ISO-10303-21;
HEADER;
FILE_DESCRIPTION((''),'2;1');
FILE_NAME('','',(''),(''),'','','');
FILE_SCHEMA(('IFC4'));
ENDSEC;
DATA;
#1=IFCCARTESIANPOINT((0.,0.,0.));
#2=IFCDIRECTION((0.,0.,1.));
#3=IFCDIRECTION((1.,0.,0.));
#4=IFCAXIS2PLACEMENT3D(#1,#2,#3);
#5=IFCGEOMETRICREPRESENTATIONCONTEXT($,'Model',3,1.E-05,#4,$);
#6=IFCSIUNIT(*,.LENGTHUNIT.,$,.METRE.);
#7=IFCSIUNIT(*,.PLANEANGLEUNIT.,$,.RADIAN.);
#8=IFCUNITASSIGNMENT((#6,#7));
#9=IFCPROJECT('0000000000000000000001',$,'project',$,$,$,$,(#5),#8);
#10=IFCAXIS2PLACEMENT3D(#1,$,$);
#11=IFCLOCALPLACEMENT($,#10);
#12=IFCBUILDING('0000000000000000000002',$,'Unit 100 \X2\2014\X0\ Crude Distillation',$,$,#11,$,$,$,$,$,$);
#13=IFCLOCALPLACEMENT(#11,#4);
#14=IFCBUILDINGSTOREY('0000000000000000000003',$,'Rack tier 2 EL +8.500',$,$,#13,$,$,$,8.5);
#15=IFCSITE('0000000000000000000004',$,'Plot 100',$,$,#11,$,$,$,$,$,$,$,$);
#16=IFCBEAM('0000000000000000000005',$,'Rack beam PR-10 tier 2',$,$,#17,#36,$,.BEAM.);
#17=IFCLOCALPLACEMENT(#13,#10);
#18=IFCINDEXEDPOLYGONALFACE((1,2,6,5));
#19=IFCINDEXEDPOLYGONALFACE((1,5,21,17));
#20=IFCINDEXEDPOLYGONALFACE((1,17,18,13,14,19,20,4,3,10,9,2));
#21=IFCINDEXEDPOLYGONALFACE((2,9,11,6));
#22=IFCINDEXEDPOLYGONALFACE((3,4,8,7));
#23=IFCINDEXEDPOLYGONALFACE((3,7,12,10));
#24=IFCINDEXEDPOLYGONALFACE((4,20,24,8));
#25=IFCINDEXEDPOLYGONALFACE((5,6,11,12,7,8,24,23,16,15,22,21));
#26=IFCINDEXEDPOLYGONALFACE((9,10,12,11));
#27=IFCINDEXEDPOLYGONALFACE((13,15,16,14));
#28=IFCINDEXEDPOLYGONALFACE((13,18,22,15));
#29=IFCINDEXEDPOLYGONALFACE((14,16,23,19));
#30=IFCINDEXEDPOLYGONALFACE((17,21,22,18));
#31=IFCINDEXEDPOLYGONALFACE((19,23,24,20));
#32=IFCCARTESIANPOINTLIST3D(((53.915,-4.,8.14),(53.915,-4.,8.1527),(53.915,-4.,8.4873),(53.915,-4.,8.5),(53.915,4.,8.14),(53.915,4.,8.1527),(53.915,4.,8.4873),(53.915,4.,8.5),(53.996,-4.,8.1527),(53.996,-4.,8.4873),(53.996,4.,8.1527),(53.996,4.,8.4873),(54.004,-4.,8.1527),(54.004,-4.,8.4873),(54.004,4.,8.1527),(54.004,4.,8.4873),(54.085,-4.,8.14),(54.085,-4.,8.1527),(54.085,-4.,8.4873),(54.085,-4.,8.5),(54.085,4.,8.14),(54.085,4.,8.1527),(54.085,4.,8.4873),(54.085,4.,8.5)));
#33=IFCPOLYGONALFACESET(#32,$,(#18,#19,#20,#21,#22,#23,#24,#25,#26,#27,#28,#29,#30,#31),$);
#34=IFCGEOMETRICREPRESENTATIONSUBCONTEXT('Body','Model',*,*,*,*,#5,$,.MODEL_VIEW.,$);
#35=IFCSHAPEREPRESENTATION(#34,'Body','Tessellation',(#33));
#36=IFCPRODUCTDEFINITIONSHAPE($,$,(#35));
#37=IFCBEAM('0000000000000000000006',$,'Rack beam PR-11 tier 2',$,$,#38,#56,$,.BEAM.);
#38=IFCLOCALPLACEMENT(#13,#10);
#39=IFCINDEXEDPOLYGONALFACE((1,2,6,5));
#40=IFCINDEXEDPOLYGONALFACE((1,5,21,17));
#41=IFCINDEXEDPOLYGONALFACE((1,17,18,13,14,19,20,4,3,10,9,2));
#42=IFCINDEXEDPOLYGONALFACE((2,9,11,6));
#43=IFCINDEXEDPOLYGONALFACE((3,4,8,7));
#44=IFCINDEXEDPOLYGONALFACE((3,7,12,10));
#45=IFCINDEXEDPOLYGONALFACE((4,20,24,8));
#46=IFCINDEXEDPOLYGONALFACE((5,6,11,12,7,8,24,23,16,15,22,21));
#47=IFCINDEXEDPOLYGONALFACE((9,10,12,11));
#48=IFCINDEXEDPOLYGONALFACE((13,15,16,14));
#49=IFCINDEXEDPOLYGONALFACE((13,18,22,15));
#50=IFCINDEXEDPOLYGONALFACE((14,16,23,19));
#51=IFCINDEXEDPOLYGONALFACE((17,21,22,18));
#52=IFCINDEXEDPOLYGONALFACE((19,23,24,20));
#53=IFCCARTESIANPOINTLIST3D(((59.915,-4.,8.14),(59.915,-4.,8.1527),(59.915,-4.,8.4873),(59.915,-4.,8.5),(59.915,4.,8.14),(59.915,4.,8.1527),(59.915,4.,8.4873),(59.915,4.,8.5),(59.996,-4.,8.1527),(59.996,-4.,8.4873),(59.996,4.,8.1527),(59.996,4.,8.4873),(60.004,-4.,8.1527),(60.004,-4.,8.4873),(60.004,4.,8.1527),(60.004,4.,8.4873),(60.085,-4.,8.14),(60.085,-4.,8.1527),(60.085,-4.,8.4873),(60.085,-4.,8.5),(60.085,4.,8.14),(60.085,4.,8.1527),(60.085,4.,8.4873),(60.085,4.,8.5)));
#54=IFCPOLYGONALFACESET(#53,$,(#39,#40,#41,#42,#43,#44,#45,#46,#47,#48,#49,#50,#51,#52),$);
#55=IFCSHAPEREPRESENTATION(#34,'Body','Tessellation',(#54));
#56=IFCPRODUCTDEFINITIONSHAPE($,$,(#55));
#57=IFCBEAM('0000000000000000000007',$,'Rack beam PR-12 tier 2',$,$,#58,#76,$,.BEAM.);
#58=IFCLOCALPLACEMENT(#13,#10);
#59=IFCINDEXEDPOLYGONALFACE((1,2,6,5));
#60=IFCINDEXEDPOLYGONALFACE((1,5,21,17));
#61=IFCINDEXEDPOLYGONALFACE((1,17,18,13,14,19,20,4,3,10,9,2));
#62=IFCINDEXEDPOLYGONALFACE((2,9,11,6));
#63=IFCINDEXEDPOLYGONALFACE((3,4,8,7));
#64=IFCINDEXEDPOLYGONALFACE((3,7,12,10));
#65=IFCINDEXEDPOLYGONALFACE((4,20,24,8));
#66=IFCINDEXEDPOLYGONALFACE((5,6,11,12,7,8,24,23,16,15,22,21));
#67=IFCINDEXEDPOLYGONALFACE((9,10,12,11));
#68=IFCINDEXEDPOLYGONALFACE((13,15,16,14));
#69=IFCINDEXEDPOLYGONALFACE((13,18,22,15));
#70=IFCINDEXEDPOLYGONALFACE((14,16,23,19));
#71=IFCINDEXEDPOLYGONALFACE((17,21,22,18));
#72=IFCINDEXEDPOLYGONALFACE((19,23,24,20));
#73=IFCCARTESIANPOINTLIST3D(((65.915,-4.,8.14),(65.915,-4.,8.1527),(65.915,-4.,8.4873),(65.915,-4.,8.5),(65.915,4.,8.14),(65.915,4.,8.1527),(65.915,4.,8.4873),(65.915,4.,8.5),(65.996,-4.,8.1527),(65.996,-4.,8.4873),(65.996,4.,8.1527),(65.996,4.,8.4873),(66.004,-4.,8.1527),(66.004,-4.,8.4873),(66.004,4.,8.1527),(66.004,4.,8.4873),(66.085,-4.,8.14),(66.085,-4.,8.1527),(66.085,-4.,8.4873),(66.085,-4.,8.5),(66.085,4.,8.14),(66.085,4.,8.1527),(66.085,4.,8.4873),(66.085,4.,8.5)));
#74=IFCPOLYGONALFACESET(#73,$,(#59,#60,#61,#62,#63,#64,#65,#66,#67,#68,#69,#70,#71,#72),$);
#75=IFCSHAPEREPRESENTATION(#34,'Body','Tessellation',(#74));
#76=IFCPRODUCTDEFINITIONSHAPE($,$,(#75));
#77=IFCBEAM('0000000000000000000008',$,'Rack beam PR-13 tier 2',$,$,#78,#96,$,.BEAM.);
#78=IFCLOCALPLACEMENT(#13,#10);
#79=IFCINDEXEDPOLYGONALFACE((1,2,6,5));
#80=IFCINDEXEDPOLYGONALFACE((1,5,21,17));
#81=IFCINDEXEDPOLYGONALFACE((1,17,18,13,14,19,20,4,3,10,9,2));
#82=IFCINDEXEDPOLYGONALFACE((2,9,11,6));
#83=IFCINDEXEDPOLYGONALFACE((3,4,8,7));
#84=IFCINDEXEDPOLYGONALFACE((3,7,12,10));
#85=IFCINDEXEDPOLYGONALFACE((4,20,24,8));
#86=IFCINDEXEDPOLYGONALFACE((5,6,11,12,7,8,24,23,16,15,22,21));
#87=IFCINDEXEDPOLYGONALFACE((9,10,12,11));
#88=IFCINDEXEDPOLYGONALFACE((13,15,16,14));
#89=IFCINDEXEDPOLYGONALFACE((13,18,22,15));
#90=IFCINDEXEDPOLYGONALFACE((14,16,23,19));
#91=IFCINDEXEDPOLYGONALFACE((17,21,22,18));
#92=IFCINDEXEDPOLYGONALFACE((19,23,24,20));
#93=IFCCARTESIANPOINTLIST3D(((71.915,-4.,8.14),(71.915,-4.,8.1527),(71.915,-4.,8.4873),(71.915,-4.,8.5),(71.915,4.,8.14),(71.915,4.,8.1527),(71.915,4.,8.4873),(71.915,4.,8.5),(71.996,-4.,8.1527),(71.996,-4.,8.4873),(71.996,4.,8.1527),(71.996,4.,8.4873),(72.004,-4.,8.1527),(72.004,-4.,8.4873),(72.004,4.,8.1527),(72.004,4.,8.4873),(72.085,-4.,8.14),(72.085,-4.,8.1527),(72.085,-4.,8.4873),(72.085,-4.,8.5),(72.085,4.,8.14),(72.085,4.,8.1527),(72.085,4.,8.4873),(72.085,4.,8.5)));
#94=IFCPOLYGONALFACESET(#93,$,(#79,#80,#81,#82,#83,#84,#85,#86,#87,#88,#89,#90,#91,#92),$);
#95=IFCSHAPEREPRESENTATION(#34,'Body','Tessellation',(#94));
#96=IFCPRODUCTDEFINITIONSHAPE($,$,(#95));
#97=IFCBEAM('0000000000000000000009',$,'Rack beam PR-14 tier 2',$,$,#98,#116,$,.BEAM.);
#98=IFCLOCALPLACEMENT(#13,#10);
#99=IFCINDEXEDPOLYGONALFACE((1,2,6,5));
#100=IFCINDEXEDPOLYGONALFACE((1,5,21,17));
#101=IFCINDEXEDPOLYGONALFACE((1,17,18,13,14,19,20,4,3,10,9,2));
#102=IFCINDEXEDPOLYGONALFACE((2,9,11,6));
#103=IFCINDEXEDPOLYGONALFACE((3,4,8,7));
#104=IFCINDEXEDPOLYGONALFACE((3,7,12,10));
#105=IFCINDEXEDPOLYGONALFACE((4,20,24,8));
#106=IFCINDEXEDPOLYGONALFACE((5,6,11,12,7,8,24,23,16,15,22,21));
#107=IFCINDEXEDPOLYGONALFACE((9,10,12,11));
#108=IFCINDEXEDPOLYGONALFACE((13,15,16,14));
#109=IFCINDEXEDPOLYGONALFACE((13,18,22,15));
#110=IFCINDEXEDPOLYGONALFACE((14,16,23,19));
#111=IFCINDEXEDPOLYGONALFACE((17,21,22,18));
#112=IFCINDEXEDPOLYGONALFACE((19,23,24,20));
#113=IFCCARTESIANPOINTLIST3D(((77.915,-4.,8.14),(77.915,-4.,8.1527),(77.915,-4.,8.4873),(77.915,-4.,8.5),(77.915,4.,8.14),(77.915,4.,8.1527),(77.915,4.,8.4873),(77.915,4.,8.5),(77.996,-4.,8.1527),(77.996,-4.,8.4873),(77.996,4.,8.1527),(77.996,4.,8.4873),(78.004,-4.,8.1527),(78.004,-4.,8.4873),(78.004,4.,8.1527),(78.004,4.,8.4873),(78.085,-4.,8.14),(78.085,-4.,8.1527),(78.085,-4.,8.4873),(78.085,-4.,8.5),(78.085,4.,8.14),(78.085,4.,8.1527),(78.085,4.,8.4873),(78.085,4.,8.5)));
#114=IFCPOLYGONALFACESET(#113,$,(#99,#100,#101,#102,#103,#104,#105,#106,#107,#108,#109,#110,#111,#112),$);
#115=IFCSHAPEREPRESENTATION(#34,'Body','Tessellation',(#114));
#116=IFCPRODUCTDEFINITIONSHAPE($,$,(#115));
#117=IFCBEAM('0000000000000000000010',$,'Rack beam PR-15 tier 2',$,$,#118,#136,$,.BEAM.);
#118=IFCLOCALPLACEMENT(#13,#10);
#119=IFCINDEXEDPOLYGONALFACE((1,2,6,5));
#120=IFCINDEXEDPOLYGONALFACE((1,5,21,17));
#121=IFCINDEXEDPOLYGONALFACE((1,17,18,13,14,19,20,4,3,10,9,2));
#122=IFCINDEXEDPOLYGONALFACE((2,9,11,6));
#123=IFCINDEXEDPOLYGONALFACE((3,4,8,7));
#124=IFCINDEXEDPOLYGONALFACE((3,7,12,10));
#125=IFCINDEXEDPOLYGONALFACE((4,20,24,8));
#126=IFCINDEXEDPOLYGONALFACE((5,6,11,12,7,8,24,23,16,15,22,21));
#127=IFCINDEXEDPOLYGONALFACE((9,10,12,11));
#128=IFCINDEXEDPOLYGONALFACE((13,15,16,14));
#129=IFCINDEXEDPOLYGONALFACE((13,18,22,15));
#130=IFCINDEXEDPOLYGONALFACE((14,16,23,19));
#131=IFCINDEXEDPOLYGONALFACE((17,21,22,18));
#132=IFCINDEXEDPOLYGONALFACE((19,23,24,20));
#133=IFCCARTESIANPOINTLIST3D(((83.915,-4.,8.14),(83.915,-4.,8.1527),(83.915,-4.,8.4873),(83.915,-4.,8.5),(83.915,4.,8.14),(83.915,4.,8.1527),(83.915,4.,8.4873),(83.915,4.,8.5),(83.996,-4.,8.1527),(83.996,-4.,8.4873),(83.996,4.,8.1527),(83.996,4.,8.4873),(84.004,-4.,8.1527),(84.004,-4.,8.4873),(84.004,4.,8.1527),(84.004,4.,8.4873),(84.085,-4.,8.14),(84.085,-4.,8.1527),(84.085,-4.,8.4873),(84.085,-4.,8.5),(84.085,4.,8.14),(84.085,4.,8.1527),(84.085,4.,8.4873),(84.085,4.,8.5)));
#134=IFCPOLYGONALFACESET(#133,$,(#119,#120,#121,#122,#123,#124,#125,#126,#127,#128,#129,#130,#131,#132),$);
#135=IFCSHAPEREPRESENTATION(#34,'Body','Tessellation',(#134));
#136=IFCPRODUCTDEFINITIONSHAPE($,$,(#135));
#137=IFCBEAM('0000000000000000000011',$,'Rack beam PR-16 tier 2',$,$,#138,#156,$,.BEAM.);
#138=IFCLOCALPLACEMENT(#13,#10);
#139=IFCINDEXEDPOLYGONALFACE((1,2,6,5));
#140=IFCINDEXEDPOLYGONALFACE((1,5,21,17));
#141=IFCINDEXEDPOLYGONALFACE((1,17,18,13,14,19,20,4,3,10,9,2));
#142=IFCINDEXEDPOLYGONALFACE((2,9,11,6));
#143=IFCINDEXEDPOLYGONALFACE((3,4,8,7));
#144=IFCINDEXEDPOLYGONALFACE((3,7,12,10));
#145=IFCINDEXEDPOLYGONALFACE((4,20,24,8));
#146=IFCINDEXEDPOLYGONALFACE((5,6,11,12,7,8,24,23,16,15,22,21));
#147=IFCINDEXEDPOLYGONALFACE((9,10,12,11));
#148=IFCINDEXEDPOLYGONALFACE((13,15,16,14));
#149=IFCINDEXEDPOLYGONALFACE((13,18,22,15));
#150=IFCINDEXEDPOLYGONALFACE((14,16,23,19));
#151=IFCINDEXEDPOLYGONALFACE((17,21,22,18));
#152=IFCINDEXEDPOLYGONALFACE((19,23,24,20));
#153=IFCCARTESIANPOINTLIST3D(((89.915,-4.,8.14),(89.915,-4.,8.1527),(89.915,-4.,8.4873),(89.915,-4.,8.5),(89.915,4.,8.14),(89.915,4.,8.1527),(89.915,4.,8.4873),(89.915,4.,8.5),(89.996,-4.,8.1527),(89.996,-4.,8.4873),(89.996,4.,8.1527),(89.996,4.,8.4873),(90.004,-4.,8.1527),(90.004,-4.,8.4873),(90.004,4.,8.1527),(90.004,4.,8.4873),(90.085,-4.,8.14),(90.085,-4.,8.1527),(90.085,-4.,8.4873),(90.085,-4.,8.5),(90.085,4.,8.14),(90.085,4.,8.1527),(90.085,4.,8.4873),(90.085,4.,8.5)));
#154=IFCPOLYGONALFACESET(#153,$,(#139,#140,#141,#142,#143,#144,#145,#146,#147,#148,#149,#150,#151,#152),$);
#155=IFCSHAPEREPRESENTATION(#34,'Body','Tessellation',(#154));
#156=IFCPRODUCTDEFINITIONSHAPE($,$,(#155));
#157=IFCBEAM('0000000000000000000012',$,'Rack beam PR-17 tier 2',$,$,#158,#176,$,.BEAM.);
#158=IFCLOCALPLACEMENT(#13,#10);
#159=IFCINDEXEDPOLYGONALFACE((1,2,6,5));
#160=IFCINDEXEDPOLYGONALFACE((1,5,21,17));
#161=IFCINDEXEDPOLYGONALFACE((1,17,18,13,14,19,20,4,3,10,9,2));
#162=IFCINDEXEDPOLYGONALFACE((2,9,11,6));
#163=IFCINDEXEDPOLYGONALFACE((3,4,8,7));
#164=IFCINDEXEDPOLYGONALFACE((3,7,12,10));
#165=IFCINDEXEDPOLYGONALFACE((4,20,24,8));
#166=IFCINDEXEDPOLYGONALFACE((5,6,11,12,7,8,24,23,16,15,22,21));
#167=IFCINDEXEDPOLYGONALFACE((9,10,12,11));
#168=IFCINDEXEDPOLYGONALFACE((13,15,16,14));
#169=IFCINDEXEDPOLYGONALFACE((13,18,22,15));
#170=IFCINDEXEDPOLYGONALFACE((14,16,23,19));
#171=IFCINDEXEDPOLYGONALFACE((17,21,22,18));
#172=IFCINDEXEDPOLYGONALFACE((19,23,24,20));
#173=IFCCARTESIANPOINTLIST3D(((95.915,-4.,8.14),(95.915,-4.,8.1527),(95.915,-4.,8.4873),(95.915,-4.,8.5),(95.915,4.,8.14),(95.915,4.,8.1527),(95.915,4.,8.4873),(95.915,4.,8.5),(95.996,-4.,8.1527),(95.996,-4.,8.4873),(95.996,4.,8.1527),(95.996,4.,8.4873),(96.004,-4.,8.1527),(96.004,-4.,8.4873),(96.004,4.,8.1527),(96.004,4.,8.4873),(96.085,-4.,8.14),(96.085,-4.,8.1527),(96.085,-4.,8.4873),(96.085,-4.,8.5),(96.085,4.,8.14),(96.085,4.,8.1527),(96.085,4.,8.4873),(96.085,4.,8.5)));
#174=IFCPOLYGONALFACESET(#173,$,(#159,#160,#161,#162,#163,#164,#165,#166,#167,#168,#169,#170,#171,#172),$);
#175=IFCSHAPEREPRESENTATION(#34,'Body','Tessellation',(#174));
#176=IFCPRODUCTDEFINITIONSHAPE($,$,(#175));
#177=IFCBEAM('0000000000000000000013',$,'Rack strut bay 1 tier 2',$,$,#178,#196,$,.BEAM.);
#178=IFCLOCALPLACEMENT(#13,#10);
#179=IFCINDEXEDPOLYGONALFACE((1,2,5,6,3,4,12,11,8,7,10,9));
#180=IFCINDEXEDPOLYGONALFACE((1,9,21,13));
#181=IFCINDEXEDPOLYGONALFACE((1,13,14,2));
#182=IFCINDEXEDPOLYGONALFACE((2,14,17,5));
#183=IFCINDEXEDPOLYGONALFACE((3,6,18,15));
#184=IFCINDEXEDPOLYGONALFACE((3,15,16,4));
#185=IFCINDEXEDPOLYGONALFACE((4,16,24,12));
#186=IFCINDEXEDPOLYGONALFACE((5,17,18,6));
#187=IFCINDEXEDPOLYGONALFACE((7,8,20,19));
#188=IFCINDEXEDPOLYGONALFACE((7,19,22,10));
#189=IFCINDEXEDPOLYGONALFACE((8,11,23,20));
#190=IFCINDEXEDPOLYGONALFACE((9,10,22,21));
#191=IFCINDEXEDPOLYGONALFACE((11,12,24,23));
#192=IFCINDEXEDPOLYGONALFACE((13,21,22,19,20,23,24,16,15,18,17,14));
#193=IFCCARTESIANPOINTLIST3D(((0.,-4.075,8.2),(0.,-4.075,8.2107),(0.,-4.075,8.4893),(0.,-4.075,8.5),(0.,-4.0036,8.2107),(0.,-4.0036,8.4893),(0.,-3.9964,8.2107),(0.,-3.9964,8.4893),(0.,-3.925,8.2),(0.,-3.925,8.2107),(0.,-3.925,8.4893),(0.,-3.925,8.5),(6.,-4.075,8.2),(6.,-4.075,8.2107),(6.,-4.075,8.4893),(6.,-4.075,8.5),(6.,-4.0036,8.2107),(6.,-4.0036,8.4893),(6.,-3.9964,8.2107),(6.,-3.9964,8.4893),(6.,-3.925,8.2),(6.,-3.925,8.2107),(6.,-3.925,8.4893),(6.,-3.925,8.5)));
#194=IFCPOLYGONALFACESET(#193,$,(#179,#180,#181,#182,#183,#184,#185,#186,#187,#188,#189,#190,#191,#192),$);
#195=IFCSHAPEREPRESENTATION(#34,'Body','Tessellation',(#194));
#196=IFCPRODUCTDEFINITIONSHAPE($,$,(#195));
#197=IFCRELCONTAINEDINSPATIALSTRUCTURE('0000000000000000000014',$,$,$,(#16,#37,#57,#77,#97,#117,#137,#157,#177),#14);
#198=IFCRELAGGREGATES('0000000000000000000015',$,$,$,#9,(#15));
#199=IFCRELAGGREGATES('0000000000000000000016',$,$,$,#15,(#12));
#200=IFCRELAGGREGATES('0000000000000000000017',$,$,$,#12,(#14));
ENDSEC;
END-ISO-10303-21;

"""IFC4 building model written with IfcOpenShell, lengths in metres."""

from ifc_helpers import new_model, si_unit, frame, origin, origin_with_axes, origin_2d, place, context, subcontext, project, spatial, i_section, extrude, element, save


model = new_model("IFC4")

# Units and contexts
model_context = context("Model", 3, precision=1e-05, world=origin_with_axes())
body_context = subcontext(model_context, "Body", "Model", "MODEL_VIEW")
ifc_project = project(units=[si_unit("LENGTHUNIT", "METRE"), si_unit("PLANEANGLEUNIT", "RADIAN")], contexts=[model_context])

# Site, building, storey
placement = place(None, origin())
site = spatial("IfcSite", under=ifc_project, at=placement, Name="Plot 100")
building = spatial("IfcBuilding", under=site, at=placement, Name="Unit 100 — Crude Distillation")
storey_placement = place(placement, origin_with_axes())
storey = spatial("IfcBuildingStorey", under=building, at=storey_placement, Name="Rack tier 2 EL +8.500", Elevation=8.5)

# Beams
beam_1_placement = place(storey_placement, origin_with_axes())
element("IfcBeam", 1, at=beam_1_placement, inside=storey, Name="Rack beam PR-10 tier 2", PredefinedType="BEAM", context=body_context, shape_type="SweptSolid", body=[
    extrude(i_section(OverallWidth=0.17, OverallDepth=0.36, WebThickness=0.008, FlangeThickness=0.0127, at=origin_2d()), frame((54.0, -4.0, 8.32), z_axis=(0.0, 1.0, 0.0), x_axis=(-1.0, 0.0, 0.0)), (0.0, 0.0, 1.0), 8.0),
])
beam_2_placement = place(storey_placement, origin_with_axes())
element("IfcBeam", 2, at=beam_2_placement, inside=storey, Name="Rack beam PR-11 tier 2", PredefinedType="BEAM", context=body_context, shape_type="SweptSolid", body=[
    extrude(i_section(OverallWidth=0.17, OverallDepth=0.36, WebThickness=0.008, FlangeThickness=0.0127, at=origin_2d()), frame((60.0, -4.0, 8.32), z_axis=(0.0, 1.0, 0.0), x_axis=(-1.0, 0.0, 0.0)), (0.0, 0.0, 1.0), 8.0),
])
beam_3_placement = place(storey_placement, origin_with_axes())
element("IfcBeam", 3, at=beam_3_placement, inside=storey, Name="Rack beam PR-12 tier 2", PredefinedType="BEAM", context=body_context, shape_type="SweptSolid", body=[
    extrude(i_section(OverallWidth=0.17, OverallDepth=0.36, WebThickness=0.008, FlangeThickness=0.0127, at=origin_2d()), frame((66.0, -4.0, 8.32), z_axis=(0.0, 1.0, 0.0), x_axis=(-1.0, 0.0, 0.0)), (0.0, 0.0, 1.0), 8.0),
])
beam_4_placement = place(storey_placement, origin_with_axes())
element("IfcBeam", 4, at=beam_4_placement, inside=storey, Name="Rack beam PR-13 tier 2", PredefinedType="BEAM", context=body_context, shape_type="SweptSolid", body=[
    extrude(i_section(OverallWidth=0.17, OverallDepth=0.36, WebThickness=0.008, FlangeThickness=0.0127, at=origin_2d()), frame((72.0, -4.0, 8.32), z_axis=(0.0, 1.0, 0.0), x_axis=(-1.0, 0.0, 0.0)), (0.0, 0.0, 1.0), 8.0),
])
beam_5_placement = place(storey_placement, origin_with_axes())
element("IfcBeam", 5, at=beam_5_placement, inside=storey, Name="Rack beam PR-14 tier 2", PredefinedType="BEAM", context=body_context, shape_type="SweptSolid", body=[
    extrude(i_section(OverallWidth=0.17, OverallDepth=0.36, WebThickness=0.008, FlangeThickness=0.0127, at=origin_2d()), frame((78.0, -4.0, 8.32), z_axis=(0.0, 1.0, 0.0), x_axis=(-1.0, 0.0, 0.0)), (0.0, 0.0, 1.0), 8.0),
])
beam_6_placement = place(storey_placement, origin_with_axes())
element("IfcBeam", 6, at=beam_6_placement, inside=storey, Name="Rack beam PR-15 tier 2", PredefinedType="BEAM", context=body_context, shape_type="SweptSolid", body=[
    extrude(i_section(OverallWidth=0.17, OverallDepth=0.36, WebThickness=0.008, FlangeThickness=0.0127, at=origin_2d()), frame((84.0, -4.0, 8.32), z_axis=(0.0, 1.0, 0.0), x_axis=(-1.0, 0.0, 0.0)), (0.0, 0.0, 1.0), 8.0),
])
beam_7_placement = place(storey_placement, origin_with_axes())
element("IfcBeam", 7, at=beam_7_placement, inside=storey, Name="Rack beam PR-16 tier 2", PredefinedType="BEAM", context=body_context, shape_type="SweptSolid", body=[
    extrude(i_section(OverallWidth=0.17, OverallDepth=0.36, WebThickness=0.008, FlangeThickness=0.0127, at=origin_2d()), frame((90.0, -4.0, 8.32), z_axis=(0.0, 1.0, 0.0), x_axis=(-1.0, 0.0, 0.0)), (0.0, 0.0, 1.0), 8.0),
])
beam_8_placement = place(storey_placement, origin_with_axes())
element("IfcBeam", 8, at=beam_8_placement, inside=storey, Name="Rack beam PR-17 tier 2", PredefinedType="BEAM", context=body_context, shape_type="SweptSolid", body=[
    extrude(i_section(OverallWidth=0.17, OverallDepth=0.36, WebThickness=0.008, FlangeThickness=0.0127, at=origin_2d()), frame((96.0, -4.0, 8.32), z_axis=(0.0, 1.0, 0.0), x_axis=(-1.0, 0.0, 0.0)), (0.0, 0.0, 1.0), 8.0),
])
beam_9_placement = place(storey_placement, origin_with_axes())
element("IfcBeam", 9, at=beam_9_placement, inside=storey, Name="Rack strut bay 1 tier 2", PredefinedType="BEAM", context=body_context, shape_type="SweptSolid", body=[
    extrude(i_section(OverallWidth=0.15, OverallDepth=0.3, WebThickness=0.0071, FlangeThickness=0.0107, at=origin_2d()), frame((0.0, -4.0, 8.35), z_axis=(1.0, 0.0, 0.0), x_axis=(0.0, 1.0, 0.0)), (0.0, 0.0, 1.0), 6.0),
])

save(model, "model.ifc")
